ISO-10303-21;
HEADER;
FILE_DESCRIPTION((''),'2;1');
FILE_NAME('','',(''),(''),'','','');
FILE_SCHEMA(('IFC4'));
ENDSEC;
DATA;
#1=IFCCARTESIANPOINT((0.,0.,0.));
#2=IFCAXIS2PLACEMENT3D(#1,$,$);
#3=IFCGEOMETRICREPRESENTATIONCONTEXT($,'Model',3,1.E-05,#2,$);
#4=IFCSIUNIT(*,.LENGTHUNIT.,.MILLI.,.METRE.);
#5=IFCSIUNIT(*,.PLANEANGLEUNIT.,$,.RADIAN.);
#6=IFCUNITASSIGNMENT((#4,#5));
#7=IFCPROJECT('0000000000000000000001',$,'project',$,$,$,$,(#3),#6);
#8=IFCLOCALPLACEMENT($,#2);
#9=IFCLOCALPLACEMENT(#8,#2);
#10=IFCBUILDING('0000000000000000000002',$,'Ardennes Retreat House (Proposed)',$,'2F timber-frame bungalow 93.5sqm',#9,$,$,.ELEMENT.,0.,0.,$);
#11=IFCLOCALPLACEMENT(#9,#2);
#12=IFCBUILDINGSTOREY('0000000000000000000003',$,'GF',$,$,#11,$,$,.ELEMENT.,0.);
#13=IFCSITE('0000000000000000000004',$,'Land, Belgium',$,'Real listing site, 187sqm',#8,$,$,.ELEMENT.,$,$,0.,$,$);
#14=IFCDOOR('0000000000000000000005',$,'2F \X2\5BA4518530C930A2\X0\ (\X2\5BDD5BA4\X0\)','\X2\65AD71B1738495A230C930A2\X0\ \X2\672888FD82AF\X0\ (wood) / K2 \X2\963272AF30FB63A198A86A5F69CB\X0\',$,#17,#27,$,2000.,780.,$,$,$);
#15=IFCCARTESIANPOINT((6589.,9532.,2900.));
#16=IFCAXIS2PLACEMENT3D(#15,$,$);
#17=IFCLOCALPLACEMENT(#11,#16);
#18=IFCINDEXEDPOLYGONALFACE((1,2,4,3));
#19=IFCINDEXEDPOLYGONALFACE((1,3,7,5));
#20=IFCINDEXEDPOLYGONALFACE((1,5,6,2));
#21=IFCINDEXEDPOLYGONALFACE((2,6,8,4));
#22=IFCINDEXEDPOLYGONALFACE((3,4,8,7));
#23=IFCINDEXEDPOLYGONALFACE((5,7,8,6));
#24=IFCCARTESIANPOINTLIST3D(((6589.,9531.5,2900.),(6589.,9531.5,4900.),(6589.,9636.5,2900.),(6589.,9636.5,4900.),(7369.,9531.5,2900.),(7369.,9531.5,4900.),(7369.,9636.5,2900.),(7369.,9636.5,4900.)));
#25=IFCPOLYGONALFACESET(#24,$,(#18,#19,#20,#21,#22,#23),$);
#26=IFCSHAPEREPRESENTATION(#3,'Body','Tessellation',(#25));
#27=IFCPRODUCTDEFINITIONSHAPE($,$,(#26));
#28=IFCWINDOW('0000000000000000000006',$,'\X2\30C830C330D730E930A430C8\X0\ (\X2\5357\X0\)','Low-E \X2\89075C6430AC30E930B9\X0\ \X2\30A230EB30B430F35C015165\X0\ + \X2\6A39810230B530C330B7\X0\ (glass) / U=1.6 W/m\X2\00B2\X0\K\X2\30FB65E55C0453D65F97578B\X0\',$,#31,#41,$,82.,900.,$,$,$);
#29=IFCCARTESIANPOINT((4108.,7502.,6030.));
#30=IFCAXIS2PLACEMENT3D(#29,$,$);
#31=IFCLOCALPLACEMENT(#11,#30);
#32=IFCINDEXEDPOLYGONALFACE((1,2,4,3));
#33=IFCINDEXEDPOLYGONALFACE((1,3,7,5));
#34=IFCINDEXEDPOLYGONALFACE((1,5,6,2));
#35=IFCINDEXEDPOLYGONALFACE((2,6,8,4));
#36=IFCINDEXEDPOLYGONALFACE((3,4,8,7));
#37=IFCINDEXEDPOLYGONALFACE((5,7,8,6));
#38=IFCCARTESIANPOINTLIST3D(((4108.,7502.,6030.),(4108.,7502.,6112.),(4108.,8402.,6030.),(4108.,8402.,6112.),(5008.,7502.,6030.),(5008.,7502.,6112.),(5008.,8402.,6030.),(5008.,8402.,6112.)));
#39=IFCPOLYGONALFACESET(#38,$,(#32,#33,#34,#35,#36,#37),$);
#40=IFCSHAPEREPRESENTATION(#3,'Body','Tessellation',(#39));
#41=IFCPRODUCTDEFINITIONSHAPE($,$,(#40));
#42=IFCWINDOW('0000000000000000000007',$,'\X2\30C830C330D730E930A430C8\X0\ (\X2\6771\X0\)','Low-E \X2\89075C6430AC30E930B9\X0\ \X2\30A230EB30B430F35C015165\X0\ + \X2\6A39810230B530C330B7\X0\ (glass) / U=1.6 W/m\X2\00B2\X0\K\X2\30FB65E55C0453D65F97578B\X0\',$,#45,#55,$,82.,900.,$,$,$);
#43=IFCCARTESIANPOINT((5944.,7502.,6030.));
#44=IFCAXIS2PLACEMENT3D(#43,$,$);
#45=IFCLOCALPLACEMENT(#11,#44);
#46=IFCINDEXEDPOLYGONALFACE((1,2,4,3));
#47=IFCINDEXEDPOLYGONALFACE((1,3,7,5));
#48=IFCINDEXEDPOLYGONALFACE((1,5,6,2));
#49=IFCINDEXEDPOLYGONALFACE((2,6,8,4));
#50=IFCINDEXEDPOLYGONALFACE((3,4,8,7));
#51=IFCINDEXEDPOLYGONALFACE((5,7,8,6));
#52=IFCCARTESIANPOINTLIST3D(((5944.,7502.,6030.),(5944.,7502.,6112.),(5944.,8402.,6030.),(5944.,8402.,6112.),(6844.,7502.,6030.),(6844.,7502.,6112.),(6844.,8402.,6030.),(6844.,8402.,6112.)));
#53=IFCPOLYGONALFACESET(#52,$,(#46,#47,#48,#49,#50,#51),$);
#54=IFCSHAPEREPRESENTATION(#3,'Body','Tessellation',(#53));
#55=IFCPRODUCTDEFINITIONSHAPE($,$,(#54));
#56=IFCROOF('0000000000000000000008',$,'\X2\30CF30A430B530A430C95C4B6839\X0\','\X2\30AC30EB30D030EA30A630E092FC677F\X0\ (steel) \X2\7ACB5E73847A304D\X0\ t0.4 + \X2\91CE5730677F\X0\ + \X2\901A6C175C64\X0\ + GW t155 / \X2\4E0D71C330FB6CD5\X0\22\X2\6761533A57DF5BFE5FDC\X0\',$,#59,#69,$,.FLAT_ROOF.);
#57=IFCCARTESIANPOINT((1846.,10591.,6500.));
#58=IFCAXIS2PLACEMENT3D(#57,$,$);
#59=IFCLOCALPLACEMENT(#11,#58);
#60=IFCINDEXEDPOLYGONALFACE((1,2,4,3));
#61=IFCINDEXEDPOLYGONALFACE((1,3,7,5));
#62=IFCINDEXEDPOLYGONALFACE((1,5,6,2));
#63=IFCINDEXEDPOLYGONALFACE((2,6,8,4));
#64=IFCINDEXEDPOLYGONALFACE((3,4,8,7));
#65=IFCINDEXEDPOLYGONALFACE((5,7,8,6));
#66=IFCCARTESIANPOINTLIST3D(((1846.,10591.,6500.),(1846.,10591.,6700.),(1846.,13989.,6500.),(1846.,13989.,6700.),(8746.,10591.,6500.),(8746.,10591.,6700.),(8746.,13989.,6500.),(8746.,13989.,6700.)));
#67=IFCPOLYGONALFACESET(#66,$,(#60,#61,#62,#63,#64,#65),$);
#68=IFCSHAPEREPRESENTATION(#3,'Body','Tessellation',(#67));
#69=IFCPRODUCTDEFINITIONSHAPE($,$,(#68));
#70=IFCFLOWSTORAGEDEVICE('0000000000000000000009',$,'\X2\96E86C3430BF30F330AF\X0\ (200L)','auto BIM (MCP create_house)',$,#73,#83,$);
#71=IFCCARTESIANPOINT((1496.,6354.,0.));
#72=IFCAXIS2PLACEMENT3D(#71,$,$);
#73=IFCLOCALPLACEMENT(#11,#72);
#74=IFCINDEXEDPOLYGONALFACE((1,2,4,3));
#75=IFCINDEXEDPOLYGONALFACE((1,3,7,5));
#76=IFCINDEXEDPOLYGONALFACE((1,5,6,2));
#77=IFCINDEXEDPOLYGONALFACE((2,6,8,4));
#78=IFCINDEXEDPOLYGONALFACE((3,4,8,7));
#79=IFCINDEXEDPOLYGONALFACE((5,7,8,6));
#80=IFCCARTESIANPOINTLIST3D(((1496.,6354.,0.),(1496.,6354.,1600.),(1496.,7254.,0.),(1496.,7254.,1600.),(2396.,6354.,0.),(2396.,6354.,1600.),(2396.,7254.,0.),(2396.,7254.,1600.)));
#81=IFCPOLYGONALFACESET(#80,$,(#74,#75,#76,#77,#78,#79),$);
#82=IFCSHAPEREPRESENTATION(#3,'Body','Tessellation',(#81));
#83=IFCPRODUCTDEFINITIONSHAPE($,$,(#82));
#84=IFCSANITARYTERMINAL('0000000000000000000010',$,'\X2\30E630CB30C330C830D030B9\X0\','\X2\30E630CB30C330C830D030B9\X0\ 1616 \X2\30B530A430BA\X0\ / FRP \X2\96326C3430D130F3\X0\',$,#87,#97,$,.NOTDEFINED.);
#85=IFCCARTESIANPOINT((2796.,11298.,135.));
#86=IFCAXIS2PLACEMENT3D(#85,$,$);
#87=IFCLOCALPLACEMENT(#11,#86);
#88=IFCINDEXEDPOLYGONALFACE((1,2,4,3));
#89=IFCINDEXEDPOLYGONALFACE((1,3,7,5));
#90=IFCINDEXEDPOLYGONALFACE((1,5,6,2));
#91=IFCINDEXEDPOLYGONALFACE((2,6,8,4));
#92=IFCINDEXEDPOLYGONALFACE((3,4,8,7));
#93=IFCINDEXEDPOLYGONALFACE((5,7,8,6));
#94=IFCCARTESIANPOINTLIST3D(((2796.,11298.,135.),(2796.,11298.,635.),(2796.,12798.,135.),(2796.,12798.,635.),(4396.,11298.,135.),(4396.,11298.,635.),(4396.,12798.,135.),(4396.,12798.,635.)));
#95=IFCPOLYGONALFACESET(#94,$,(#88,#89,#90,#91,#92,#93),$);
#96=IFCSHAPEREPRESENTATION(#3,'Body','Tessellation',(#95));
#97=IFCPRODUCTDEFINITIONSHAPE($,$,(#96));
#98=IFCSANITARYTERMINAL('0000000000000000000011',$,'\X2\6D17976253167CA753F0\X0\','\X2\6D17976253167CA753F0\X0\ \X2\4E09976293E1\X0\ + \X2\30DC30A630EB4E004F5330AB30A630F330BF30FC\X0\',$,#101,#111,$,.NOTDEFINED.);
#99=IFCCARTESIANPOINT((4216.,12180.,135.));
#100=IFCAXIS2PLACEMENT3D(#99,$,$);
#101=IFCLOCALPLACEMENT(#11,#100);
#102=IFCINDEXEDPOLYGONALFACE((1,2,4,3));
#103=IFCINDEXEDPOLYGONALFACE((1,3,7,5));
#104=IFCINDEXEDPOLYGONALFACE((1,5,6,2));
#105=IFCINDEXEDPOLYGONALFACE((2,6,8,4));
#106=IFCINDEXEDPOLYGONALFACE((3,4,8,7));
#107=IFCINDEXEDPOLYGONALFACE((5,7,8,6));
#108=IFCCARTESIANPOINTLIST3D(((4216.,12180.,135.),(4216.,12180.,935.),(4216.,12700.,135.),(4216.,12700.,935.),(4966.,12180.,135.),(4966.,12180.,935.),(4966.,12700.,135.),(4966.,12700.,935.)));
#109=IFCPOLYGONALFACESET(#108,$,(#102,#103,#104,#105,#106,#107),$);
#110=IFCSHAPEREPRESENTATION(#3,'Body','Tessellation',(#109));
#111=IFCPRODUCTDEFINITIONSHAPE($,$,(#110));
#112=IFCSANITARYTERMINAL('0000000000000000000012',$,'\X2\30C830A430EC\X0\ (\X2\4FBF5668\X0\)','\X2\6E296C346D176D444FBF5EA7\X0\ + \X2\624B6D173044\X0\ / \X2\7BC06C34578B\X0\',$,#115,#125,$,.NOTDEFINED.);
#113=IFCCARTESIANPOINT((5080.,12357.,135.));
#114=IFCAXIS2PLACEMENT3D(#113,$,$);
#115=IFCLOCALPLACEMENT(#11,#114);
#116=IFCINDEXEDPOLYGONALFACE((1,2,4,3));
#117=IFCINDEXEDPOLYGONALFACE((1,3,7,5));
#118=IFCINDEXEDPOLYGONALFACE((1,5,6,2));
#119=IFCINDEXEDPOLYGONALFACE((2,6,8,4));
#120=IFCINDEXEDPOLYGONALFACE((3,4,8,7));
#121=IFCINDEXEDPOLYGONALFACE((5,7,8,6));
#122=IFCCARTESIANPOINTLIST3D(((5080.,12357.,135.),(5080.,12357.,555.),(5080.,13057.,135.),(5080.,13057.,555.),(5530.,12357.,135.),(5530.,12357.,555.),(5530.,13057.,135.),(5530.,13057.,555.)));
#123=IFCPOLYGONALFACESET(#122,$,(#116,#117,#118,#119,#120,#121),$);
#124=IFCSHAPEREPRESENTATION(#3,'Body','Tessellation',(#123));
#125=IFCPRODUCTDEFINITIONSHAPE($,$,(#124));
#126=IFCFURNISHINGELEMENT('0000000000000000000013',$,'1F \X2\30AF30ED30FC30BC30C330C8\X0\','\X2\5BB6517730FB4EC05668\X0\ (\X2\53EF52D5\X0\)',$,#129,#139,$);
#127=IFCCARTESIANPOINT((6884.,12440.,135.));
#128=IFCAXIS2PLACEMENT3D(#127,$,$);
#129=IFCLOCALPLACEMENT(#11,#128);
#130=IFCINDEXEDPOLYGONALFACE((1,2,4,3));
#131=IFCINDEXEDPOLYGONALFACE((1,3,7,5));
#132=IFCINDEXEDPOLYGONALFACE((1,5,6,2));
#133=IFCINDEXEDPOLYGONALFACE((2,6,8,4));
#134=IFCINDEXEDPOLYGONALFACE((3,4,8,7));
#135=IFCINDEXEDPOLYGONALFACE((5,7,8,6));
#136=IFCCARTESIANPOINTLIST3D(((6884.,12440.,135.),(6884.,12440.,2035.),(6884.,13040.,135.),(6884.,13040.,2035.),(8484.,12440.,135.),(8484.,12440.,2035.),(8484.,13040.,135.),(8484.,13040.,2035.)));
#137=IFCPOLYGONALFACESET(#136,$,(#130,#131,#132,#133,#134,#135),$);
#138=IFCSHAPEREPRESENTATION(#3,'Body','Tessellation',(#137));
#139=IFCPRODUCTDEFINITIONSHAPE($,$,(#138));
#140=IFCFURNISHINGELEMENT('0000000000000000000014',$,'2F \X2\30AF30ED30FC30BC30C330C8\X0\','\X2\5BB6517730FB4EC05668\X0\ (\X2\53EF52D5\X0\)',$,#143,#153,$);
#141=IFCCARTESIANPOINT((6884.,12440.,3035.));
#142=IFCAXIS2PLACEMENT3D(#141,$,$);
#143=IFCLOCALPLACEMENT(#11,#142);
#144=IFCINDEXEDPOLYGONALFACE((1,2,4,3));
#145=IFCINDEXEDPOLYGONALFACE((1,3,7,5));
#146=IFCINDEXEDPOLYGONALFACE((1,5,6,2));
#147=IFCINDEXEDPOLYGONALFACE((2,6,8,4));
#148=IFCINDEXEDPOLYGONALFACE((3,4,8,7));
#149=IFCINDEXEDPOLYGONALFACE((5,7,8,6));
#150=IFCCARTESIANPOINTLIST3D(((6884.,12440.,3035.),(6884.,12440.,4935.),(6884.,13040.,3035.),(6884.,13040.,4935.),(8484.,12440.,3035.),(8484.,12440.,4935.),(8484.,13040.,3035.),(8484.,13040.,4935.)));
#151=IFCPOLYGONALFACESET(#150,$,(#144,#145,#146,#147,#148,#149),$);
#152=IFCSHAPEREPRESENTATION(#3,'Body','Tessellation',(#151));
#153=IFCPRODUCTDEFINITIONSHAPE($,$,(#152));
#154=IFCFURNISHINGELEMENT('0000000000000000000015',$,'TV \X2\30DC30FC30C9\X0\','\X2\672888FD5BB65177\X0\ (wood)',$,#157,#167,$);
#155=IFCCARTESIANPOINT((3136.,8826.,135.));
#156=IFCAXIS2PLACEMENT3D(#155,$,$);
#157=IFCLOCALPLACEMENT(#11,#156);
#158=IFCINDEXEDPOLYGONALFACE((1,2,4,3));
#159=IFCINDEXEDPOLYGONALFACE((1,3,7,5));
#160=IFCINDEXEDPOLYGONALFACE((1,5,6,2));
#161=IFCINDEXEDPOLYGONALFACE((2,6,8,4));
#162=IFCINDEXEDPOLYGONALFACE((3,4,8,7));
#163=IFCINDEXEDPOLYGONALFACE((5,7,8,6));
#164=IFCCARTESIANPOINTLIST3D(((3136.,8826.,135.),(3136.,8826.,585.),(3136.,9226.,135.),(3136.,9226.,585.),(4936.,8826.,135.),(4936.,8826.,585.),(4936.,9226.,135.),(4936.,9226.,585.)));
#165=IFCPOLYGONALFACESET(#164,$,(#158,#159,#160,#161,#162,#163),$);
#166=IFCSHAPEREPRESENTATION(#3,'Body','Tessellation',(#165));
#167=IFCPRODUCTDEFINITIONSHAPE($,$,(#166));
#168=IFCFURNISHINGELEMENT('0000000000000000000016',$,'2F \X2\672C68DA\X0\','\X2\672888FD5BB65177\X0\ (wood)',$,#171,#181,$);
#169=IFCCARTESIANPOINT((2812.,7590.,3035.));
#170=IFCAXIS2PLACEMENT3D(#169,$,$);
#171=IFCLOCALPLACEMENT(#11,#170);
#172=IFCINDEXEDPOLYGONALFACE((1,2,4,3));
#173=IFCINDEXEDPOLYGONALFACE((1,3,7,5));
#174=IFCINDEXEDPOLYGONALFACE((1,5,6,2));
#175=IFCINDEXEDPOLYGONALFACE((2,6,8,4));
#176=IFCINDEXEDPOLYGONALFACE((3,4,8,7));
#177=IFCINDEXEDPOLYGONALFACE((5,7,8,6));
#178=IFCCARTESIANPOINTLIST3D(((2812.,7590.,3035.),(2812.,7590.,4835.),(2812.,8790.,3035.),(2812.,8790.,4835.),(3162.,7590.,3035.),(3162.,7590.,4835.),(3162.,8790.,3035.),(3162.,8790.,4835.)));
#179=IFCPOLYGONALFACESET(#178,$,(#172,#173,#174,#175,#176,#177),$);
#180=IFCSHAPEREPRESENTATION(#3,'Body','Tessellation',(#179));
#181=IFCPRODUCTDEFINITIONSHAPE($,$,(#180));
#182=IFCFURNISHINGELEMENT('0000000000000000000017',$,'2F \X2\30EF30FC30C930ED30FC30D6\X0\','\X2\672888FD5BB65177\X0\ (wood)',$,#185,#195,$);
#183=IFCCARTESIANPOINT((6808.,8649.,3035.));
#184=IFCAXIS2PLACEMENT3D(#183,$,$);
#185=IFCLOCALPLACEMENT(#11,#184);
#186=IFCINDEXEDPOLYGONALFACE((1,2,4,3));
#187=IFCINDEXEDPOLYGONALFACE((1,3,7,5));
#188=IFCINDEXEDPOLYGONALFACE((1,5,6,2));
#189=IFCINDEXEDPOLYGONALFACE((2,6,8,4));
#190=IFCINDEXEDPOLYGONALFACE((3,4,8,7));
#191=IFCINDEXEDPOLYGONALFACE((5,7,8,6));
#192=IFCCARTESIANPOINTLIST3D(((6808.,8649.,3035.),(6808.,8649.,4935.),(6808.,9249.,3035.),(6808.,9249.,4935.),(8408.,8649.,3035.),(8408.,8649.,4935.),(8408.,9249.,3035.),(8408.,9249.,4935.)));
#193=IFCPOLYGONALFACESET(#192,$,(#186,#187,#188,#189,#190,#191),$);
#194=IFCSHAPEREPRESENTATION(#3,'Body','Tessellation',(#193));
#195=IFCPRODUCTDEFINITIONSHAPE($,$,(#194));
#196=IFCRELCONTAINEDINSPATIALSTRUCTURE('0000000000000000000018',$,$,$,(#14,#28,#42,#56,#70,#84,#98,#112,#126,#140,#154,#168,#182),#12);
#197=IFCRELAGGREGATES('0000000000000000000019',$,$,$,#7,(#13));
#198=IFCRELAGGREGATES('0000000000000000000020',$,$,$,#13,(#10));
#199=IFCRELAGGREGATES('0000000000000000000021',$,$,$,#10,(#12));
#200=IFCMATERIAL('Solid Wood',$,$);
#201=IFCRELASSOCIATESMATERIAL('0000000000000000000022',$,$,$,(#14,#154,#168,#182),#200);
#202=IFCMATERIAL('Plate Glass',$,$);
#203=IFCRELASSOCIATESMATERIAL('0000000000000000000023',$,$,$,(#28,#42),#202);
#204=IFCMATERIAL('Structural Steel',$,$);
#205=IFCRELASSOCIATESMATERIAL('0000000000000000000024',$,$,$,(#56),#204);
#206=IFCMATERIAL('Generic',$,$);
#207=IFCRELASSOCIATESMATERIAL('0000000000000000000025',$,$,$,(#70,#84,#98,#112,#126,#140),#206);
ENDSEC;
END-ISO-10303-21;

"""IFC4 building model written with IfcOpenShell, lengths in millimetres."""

from ifc_helpers import new_model, si_unit, frame, frame_2d, origin, place, context, project, spatial, rectangle, extrude, material, element, save


model = new_model("IFC4")

# Units and contexts
model_context = context("Model", 3, precision=1e-05, world=origin())
ifc_project = project(units=[si_unit("LENGTHUNIT", "METRE", prefix="MILLI"), si_unit("PLANEANGLEUNIT", "RADIAN")], contexts=[model_context])

# Site, building, storey
site_placement = place(None, origin())
site = spatial("IfcSite", under=ifc_project, at=site_placement, Name="Land, Belgium", ObjectType="Real listing site, 187sqm", CompositionType="ELEMENT", RefElevation=0.0)
building_placement = place(site_placement, origin())
building = spatial("IfcBuilding", under=site, at=building_placement, Name="Ardennes Retreat House (Proposed)", ObjectType="2F timber-frame bungalow 93.5sqm", CompositionType="ELEMENT", ElevationOfRefHeight=0.0, ElevationOfTerrain=0.0)
storey_placement = place(building_placement, origin())
storey = spatial("IfcBuildingStorey", under=building, at=storey_placement, Name="GF", CompositionType="ELEMENT", Elevation=0.0)

# Shared definitions
ifc_material_1 = material(Name="Solid Wood")
ifc_material_2 = material(Name="Plate Glass")

# Door
door_1_placement = place(storey_placement, frame((6589.0, 9532.0, 2900.0)))
element("IfcDoor", 1, at=door_1_placement, inside=storey, material=ifc_material_1, Name="2F 室内ドア (寝室)", Description="断熱玄関ドア 木製芯 (wood) / K2 防犯・採風機構", OverallHeight=2000.0, OverallWidth=780.0, context=model_context, shape_type="SweptSolid", body=[
    extrude(rectangle(XDim=780.0, YDim=105.0, at=frame_2d((390.0, 52.0))), frame((6589.0, 9532.0, 2900.0)), (0.0, 0.0, 1.0), 2000.0),
])

# Windows
window_1_placement = place(storey_placement, frame((4108.0, 7502.0, 6030.0)))
element("IfcWindow", 2, at=window_1_placement, inside=storey, material=ifc_material_2, Name="トップライト (南)", Description="Low-E 複層ガラス アルゴン封入 + 樹脂サッシ (glass) / U=1.6 W/m²K・日射取得型", OverallHeight=82.0, OverallWidth=900.0, context=model_context, shape_type="SweptSolid", body=[
    extrude(rectangle(XDim=900.0, YDim=900.0, at=frame_2d((450.0, 450.0))), frame((4108.0, 7502.0, 6030.0)), (0.0, 0.0, 1.0), 82.0),
])
window_2_placement = place(storey_placement, frame((5944.0, 7502.0, 6030.0)))
element("IfcWindow", 3, at=window_2_placement, inside=storey, material=ifc_material_2, Name="トップライト (東)", Description="Low-E 複層ガラス アルゴン封入 + 樹脂サッシ (glass) / U=1.6 W/m²K・日射取得型", OverallHeight=82.0, OverallWidth=900.0, context=model_context, shape_type="SweptSolid", body=[
    extrude(rectangle(XDim=900.0, YDim=900.0, at=frame_2d((450.0, 450.0))), frame((5944.0, 7502.0, 6030.0)), (0.0, 0.0, 1.0), 82.0),
])

# Roof
ifc_material_3 = material(Name="Structural Steel")
roof_placement = place(storey_placement, frame((1846.0, 10591.0, 6500.0)))
element("IfcRoof", 4, at=roof_placement, inside=storey, material=ifc_material_3, Name="ハイサイド屋根", Description="ガルバリウム鋼板 (steel) 立平葺き t0.4 + 野地板 + 通気層 + GW t155 / 不燃・法22条区域対応", PredefinedType="FLAT_ROOF", context=model_context, shape_type="SweptSolid", body=[
    extrude(rectangle(XDim=6900.0, YDim=3398.0, at=frame_2d((3450.0, 1699.0))), frame((1846.0, 10591.0, 6500.0)), (0.0, 0.0, 1.0), 200.0),
])

# Flow storage device
ifc_material_4 = material(Name="Generic")
flow_storage_device_placement = place(storey_placement, frame((1496.0, 6354.0, 0.0)))
element("IfcFlowStorageDevice", 5, at=flow_storage_device_placement, inside=storey, material=ifc_material_4, Name="雨水タンク (200L)", Description="auto BIM (MCP create_house)", context=model_context, shape_type="SweptSolid", body=[
    extrude(rectangle(XDim=900.0, YDim=900.0, at=frame_2d((450.0, 450.0))), frame((1496.0, 6354.0, 0.0)), (0.0, 0.0, 1.0), 1600.0),
])

# Sanitary terminals
sanitary_terminal_1_placement = place(storey_placement, frame((2796.0, 11298.0, 135.0)))
element("IfcSanitaryTerminal", 6, at=sanitary_terminal_1_placement, inside=storey, material=ifc_material_4, Name="ユニットバス", Description="ユニットバス 1616 サイズ / FRP 防水パン", PredefinedType="NOTDEFINED", context=model_context, shape_type="SweptSolid", body=[
    extrude(rectangle(XDim=1600.0, YDim=1500.0, at=frame_2d((800.0, 750.0))), frame((2796.0, 11298.0, 135.0)), (0.0, 0.0, 1.0), 500.0),
])
sanitary_terminal_2_placement = place(storey_placement, frame((4216.0, 12180.0, 135.0)))
element("IfcSanitaryTerminal", 7, at=sanitary_terminal_2_placement, inside=storey, material=ifc_material_4, Name="洗面化粧台", Description="洗面化粧台 三面鏡 + ボウル一体カウンター", PredefinedType="NOTDEFINED", context=model_context, shape_type="SweptSolid", body=[
    extrude(rectangle(XDim=750.0, YDim=520.0, at=frame_2d((375.0, 260.0))), frame((4216.0, 12180.0, 135.0)), (0.0, 0.0, 1.0), 800.0),
])
sanitary_terminal_3_placement = place(storey_placement, frame((5080.0, 12357.0, 135.0)))
element("IfcSanitaryTerminal", 8, at=sanitary_terminal_3_placement, inside=storey, material=ifc_material_4, Name="トイレ (便器)", Description="温水洗浄便座 + 手洗い / 節水型", PredefinedType="NOTDEFINED", context=model_context, shape_type="SweptSolid", body=[
    extrude(rectangle(XDim=450.0, YDim=700.0, at=frame_2d((225.0, 350.0))), frame((5080.0, 12357.0, 135.0)), (0.0, 0.0, 1.0), 420.0),
])

# Furnishing elements
furnishing_1_placement = place(storey_placement, frame((6884.0, 12440.0, 135.0)))
element("IfcFurnishingElement", 9, at=furnishing_1_placement, inside=storey, material=ifc_material_4, Name="1F クローゼット", Description="家具・什器 (可動)", context=model_context, shape_type="SweptSolid", body=[
    extrude(rectangle(XDim=1600.0, YDim=600.0, at=frame_2d((800.0, 300.0))), frame((6884.0, 12440.0, 135.0)), (0.0, 0.0, 1.0), 1900.0),
])
furnishing_2_placement = place(storey_placement, frame((6884.0, 12440.0, 3035.0)))
element("IfcFurnishingElement", 10, at=furnishing_2_placement, inside=storey, material=ifc_material_4, Name="2F クローゼット", Description="家具・什器 (可動)", context=model_context, shape_type="SweptSolid", body=[
    extrude(rectangle(XDim=1600.0, YDim=600.0, at=frame_2d((800.0, 300.0))), frame((6884.0, 12440.0, 3035.0)), (0.0, 0.0, 1.0), 1900.0),
])
furnishing_3_placement = place(storey_placement, frame((3136.0, 8826.0, 135.0)))
element("IfcFurnishingElement", 11, at=furnishing_3_placement, inside=storey, material=ifc_material_1, Name="TV ボード", Description="木製家具 (wood)", context=model_context, shape_type="SweptSolid", body=[
    extrude(rectangle(XDim=1800.0, YDim=400.0, at=frame_2d((900.0, 200.0))), frame((3136.0, 8826.0, 135.0)), (0.0, 0.0, 1.0), 450.0),
])
furnishing_4_placement = place(storey_placement, frame((2812.0, 7590.0, 3035.0)))
element("IfcFurnishingElement", 12, at=furnishing_4_placement, inside=storey, material=ifc_material_1, Name="2F 本棚", Description="木製家具 (wood)", context=model_context, shape_type="SweptSolid", body=[
    extrude(rectangle(XDim=350.0, YDim=1200.0, at=frame_2d((175.0, 600.0))), frame((2812.0, 7590.0, 3035.0)), (0.0, 0.0, 1.0), 1800.0),
])
furnishing_5_placement = place(storey_placement, frame((6808.0, 8649.0, 3035.0)))
element("IfcFurnishingElement", 13, at=furnishing_5_placement, inside=storey, material=ifc_material_1, Name="2F ワードローブ", Description="木製家具 (wood)", context=model_context, shape_type="SweptSolid", body=[
    extrude(rectangle(XDim=1600.0, YDim=600.0, at=frame_2d((800.0, 300.0))), frame((6808.0, 8649.0, 3035.0)), (0.0, 0.0, 1.0), 1900.0),
])

save(model, "model.ifc")
